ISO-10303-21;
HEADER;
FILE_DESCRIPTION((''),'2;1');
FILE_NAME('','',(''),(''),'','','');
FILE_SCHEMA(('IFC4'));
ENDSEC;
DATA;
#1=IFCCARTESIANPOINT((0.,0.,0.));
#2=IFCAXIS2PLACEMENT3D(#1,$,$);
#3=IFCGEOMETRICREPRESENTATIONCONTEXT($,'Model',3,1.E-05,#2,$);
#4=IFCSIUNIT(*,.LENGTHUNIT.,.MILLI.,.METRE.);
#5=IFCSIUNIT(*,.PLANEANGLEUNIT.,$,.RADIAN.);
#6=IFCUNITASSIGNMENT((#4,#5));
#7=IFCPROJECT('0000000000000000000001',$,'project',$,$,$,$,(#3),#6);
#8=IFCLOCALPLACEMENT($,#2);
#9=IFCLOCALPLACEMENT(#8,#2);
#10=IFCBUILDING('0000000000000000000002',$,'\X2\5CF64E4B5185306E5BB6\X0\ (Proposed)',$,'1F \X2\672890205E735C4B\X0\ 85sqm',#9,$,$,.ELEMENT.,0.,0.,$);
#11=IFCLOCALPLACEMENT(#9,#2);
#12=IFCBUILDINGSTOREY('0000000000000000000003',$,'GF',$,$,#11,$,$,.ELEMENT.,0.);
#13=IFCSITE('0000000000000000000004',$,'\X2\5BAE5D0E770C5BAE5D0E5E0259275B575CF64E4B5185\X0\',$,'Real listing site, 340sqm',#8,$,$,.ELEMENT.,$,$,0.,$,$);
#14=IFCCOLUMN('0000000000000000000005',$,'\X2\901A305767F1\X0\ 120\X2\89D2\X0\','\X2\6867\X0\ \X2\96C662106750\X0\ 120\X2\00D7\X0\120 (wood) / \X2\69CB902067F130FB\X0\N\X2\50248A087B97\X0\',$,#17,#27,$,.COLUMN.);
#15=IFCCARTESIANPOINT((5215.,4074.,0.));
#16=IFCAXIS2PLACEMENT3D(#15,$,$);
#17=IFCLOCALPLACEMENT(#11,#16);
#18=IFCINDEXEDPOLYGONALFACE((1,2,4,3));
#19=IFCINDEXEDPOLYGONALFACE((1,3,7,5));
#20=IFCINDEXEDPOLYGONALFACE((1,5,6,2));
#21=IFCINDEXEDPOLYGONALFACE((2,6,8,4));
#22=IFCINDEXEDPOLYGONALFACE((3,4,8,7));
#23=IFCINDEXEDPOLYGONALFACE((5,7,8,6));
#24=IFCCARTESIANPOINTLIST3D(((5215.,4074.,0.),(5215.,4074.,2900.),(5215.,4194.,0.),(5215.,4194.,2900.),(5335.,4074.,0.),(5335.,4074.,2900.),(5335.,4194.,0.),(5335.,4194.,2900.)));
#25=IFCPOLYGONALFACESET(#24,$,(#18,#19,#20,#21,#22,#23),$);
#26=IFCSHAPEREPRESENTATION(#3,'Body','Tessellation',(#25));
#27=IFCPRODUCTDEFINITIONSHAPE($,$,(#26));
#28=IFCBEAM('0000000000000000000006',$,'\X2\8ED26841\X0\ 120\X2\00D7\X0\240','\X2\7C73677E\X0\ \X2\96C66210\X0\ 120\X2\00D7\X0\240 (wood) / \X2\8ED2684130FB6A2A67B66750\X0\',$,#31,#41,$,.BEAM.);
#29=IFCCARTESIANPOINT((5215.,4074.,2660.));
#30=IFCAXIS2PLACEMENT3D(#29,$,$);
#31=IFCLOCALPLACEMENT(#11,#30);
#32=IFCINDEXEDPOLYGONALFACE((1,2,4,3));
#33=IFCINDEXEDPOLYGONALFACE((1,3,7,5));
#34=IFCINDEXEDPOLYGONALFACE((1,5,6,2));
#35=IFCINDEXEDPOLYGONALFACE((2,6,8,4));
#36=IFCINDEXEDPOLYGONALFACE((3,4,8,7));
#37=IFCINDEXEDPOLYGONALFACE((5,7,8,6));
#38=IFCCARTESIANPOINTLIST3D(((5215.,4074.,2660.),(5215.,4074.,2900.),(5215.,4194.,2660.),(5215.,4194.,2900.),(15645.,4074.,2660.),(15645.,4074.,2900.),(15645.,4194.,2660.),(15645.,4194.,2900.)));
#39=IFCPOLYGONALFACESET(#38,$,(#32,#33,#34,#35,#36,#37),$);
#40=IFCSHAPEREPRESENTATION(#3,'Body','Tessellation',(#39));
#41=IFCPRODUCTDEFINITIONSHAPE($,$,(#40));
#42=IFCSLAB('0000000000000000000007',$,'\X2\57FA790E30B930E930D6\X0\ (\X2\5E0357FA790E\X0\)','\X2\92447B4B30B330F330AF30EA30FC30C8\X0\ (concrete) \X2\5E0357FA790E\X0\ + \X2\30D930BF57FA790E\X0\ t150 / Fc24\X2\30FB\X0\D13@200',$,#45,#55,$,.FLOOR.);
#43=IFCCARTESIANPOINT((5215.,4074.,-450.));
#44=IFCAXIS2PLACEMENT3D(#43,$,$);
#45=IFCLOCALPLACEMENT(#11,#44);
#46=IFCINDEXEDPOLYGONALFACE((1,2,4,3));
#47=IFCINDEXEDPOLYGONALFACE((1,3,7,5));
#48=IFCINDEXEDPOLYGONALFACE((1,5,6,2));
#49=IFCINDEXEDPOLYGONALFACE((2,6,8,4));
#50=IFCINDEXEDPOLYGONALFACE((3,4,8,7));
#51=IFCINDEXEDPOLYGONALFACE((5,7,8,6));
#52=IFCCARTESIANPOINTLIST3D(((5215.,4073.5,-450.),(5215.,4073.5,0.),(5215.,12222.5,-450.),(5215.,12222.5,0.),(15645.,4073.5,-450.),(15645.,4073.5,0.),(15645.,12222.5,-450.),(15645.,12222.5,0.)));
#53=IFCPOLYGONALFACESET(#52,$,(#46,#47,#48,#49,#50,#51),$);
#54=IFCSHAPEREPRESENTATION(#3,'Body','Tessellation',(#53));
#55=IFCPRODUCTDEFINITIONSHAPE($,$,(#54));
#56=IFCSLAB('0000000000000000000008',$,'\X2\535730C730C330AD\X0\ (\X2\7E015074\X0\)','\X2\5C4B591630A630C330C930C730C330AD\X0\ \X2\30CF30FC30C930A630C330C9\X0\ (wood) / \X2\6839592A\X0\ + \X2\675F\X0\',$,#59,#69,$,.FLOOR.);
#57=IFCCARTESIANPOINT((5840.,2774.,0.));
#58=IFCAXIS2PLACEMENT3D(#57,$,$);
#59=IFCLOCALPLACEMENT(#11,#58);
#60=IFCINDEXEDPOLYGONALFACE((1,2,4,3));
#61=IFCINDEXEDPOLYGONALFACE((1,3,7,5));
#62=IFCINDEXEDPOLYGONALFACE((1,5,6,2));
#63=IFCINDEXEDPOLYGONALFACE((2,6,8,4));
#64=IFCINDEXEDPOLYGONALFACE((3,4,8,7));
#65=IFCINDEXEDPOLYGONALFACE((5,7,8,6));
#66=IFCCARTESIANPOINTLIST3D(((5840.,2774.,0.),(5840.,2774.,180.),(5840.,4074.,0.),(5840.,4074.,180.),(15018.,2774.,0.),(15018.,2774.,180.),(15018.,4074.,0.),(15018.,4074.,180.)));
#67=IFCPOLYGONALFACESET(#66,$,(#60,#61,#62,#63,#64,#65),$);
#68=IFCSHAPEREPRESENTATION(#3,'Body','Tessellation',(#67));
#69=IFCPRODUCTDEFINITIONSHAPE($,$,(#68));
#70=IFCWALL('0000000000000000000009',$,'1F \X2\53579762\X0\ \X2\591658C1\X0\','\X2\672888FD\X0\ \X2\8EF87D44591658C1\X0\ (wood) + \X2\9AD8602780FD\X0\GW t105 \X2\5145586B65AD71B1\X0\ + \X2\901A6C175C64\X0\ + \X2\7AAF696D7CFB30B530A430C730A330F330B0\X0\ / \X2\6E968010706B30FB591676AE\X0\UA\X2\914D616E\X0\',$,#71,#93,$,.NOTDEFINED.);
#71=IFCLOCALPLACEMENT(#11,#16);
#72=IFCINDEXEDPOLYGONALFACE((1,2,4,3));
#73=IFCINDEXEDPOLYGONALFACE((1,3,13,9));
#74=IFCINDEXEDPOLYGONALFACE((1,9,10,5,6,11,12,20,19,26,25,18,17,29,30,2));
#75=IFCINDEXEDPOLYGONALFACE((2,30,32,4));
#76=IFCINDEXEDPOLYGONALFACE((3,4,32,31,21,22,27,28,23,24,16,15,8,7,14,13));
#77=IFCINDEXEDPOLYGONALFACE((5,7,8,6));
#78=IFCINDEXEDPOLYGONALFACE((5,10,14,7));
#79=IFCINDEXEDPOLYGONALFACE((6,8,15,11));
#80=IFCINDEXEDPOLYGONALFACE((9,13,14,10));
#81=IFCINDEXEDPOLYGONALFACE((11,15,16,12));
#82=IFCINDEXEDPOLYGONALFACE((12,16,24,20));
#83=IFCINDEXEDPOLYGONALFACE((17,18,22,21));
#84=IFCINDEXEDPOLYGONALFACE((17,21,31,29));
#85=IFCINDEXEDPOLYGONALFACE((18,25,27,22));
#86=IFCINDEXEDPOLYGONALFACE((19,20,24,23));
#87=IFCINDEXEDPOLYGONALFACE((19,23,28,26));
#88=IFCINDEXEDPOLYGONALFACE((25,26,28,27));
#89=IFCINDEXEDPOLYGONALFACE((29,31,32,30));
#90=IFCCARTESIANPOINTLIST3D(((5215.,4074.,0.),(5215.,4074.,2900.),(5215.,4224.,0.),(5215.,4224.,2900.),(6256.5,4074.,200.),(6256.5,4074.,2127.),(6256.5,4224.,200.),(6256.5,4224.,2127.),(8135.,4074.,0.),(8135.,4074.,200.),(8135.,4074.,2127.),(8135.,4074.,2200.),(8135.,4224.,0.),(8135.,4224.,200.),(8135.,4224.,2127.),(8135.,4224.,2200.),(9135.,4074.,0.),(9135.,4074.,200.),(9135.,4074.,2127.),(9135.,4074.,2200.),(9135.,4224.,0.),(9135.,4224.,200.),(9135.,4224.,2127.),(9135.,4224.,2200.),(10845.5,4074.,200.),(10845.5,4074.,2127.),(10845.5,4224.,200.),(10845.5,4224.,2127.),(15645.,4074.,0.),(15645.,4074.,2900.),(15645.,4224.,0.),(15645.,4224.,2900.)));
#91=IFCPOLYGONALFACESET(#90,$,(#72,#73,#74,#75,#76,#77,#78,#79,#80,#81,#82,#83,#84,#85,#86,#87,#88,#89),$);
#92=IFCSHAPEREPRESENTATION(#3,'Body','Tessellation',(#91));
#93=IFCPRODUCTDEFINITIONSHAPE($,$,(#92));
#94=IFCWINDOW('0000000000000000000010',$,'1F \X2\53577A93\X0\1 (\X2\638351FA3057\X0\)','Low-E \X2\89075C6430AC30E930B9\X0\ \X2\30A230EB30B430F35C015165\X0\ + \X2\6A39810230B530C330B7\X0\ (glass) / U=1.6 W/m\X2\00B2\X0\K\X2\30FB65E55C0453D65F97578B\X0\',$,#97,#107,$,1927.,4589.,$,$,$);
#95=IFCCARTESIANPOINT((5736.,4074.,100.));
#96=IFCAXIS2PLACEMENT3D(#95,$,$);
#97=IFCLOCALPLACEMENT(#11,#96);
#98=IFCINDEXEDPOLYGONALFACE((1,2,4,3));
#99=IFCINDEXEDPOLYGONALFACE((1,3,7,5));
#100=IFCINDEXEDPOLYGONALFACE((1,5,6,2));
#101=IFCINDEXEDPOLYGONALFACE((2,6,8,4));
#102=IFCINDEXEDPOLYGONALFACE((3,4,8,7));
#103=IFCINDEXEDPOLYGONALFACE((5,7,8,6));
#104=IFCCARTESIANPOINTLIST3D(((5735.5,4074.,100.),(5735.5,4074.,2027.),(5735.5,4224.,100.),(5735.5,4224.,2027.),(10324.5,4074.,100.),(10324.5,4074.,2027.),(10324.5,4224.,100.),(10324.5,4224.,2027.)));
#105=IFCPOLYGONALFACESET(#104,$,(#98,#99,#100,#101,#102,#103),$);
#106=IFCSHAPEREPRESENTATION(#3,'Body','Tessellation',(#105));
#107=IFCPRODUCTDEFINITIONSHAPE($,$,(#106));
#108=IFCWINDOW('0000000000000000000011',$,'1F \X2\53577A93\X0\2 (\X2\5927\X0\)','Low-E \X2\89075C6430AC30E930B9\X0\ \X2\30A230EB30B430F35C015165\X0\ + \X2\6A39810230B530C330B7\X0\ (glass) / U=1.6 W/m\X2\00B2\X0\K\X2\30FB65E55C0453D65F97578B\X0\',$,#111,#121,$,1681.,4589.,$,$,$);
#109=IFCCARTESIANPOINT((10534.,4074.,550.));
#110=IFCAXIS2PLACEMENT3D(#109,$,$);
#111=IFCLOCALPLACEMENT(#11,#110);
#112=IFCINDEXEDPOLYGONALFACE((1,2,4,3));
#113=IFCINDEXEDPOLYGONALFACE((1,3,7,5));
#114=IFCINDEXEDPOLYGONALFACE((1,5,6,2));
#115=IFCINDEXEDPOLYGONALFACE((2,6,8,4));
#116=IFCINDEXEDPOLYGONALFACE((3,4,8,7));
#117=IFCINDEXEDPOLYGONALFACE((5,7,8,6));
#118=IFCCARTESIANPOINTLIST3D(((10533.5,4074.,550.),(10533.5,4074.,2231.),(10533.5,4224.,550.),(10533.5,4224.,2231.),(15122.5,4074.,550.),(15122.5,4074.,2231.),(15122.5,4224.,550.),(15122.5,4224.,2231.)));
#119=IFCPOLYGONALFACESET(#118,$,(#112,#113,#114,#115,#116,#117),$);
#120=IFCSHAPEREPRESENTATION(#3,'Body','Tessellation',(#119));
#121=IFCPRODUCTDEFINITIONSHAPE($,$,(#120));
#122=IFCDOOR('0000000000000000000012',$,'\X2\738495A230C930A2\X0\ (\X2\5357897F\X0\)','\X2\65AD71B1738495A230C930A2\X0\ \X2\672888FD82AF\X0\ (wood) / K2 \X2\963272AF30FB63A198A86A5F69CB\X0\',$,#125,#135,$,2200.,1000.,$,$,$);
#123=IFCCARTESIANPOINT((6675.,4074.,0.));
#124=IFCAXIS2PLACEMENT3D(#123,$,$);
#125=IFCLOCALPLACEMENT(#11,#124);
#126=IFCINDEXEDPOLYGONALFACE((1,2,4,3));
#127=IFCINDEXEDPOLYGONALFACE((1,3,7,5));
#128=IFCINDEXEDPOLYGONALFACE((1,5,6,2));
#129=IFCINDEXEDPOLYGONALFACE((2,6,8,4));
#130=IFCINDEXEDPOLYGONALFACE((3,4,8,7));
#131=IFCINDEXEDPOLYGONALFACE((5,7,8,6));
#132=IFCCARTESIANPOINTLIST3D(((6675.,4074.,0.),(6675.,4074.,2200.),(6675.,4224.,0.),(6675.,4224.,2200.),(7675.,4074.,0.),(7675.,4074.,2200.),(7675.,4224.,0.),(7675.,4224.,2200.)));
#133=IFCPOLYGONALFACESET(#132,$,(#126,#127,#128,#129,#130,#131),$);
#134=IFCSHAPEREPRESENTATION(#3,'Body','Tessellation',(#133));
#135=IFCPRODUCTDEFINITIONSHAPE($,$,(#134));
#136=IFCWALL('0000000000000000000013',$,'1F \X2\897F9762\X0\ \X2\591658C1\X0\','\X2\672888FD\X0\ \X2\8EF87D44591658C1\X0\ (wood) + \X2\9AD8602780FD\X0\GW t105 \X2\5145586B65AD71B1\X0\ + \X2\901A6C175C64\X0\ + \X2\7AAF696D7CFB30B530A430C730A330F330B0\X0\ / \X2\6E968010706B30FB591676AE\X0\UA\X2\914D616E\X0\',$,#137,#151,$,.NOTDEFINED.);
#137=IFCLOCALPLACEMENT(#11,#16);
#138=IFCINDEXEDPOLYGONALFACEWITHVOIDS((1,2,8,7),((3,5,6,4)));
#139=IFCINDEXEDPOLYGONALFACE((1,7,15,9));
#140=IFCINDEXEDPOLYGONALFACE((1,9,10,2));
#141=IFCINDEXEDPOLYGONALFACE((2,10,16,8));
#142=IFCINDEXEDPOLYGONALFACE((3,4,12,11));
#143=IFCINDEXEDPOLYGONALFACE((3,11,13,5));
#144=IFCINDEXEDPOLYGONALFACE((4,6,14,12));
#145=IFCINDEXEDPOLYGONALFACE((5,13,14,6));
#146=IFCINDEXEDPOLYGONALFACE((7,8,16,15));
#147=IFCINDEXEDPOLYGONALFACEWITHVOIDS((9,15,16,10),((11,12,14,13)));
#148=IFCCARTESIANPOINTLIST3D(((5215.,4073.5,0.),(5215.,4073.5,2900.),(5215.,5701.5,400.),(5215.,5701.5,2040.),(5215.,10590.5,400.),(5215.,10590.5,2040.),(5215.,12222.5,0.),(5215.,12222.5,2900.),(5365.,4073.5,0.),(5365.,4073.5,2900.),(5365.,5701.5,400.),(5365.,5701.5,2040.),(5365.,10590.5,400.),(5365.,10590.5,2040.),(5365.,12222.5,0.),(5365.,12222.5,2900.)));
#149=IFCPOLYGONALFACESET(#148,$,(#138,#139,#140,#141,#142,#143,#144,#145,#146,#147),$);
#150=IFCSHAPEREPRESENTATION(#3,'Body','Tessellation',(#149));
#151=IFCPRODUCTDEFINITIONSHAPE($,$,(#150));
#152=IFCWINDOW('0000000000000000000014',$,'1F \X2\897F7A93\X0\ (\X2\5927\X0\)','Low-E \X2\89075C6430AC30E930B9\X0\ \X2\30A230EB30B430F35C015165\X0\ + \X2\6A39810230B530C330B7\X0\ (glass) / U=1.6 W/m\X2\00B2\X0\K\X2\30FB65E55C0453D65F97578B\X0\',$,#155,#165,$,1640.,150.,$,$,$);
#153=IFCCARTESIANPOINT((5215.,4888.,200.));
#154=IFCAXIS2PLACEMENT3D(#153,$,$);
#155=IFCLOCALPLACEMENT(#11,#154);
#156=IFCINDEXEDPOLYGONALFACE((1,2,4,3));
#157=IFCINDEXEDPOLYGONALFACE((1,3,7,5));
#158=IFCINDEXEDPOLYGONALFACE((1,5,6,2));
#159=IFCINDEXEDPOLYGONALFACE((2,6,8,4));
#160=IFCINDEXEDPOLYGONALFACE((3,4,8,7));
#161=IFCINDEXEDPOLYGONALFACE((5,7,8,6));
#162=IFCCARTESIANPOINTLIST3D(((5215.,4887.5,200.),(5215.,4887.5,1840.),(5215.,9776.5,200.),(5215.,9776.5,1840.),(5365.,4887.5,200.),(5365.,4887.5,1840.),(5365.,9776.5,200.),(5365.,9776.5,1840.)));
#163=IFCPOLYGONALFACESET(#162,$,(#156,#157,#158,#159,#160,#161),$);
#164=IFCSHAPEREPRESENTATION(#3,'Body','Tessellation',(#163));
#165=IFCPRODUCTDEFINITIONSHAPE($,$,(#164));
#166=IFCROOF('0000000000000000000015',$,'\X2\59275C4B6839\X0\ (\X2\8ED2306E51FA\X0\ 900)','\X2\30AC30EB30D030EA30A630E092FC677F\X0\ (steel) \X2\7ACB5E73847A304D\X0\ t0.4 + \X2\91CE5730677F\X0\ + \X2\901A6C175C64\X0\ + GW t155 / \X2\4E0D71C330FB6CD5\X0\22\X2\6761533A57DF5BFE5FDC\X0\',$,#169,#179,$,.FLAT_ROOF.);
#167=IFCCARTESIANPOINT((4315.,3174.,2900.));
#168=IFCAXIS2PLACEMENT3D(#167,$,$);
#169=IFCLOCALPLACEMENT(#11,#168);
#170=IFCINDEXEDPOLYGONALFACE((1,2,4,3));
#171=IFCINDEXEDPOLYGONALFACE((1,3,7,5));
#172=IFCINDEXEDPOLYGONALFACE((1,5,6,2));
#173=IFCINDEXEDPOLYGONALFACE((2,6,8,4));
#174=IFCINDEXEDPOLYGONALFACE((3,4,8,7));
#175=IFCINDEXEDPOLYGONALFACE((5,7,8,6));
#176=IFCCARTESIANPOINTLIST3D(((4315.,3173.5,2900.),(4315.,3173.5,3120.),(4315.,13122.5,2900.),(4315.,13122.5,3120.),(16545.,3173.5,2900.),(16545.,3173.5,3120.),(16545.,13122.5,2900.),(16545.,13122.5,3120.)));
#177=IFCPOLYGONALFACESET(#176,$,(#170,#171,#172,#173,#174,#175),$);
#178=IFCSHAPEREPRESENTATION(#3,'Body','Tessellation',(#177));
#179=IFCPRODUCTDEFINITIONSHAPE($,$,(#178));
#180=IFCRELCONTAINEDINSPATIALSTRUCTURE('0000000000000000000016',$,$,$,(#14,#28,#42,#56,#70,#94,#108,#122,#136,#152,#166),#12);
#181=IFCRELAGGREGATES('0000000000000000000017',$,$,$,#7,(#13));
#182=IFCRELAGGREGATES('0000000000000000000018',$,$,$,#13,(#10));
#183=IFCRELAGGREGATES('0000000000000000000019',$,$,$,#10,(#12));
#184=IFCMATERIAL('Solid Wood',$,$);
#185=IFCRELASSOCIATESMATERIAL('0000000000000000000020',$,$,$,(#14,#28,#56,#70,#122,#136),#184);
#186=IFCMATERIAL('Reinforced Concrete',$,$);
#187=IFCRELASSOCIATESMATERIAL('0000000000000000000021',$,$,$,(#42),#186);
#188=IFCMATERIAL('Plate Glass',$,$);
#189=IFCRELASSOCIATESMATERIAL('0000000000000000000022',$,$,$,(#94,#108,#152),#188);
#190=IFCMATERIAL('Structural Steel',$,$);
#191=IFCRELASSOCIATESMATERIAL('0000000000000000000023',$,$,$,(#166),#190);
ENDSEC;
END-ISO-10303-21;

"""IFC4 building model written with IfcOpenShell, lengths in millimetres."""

from ifc_helpers import new_model, si_unit, frame, frame_2d, origin, place, context, project, spatial, rectangle, extrude, material, element, fill, save


model = new_model("IFC4")

# Units and contexts
model_context = context("Model", 3, precision=1e-05, world=origin())
ifc_project = project(units=[si_unit("LENGTHUNIT", "METRE", prefix="MILLI"), si_unit("PLANEANGLEUNIT", "RADIAN")], contexts=[model_context])

# Site, building, storey
site_placement = place(None, origin())
site = spatial("IfcSite", under=ifc_project, at=site_placement, Name="宮崎県宮崎市大字島之内", ObjectType="Real listing site, 340sqm", CompositionType="ELEMENT", RefElevation=0.0)
building_placement = place(site_placement, origin())
building = spatial("IfcBuilding", under=site, at=building_placement, Name="島之内の家 (Proposed)", ObjectType="1F 木造平屋 85sqm", CompositionType="ELEMENT", ElevationOfRefHeight=0.0, ElevationOfTerrain=0.0)
storey_placement = place(building_placement, origin())
storey = spatial("IfcBuildingStorey", under=building, at=storey_placement, Name="GF", CompositionType="ELEMENT", Elevation=0.0)

# Column
ifc_material_1 = material(Name="Solid Wood")
column_placement = place(storey_placement, frame((5215.0, 4074.0, 0.0)))
element("IfcColumn", 1, at=column_placement, inside=storey, material=ifc_material_1, Name="通し柱 120角", Description="桧 集成材 120×120 (wood) / 構造柱・N値計算", PredefinedType="COLUMN", context=model_context, shape_type="SweptSolid", body=[
    extrude(rectangle(XDim=120.0, YDim=120.0, at=frame_2d((60.0, 60.0))), frame((5215.0, 4074.0, 0.0)), (0.0, 0.0, 1.0), 2900.0),
])

# Beam
beam_1_placement = place(storey_placement, frame((5215.0, 4074.0, 2660.0)))
element("IfcBeam", 2, at=beam_1_placement, inside=storey, material=ifc_material_1, Name="軒桁 120×240", Description="米松 集成 120×240 (wood) / 軒桁・横架材", PredefinedType="BEAM", context=model_context, shape_type="SweptSolid", body=[
    extrude(rectangle(XDim=10430.0, YDim=120.0, at=frame_2d((5215.0, 60.0))), frame((5215.0, 4074.0, 2660.0)), (0.0, 0.0, 1.0), 240.0),
])

# Slabs
ifc_material_2 = material(Name="Reinforced Concrete")
slab_1_placement = place(storey_placement, frame((5215.0, 4074.0, -450.0)))
element("IfcSlab", 3, at=slab_1_placement, inside=storey, material=ifc_material_2, Name="基礎スラブ (布基礎)", Description="鉄筋コンクリート (concrete) 布基礎 + ベタ基礎 t150 / Fc24・D13@200", PredefinedType="FLOOR", context=model_context, shape_type="SweptSolid", body=[
    extrude(rectangle(XDim=10430.0, YDim=8149.0, at=frame_2d((5215.0, 4074.0))), frame((5215.0, 4074.0, -450.0)), (0.0, 0.0, 1.0), 450.0),
])
slab_2_placement = place(storey_placement, frame((5840.0, 2774.0, 0.0)))
element("IfcSlab", 4, at=slab_2_placement, inside=storey, material=ifc_material_1, Name="南デッキ (縁側)", Description="屋外ウッドデッキ ハードウッド (wood) / 根太 + 束", PredefinedType="FLOOR", context=model_context, shape_type="SweptSolid", body=[
    extrude(rectangle(XDim=9178.0, YDim=1300.0, at=frame_2d((4589.0, 650.0))), frame((5840.0, 2774.0, 0.0)), (0.0, 0.0, 1.0), 180.0),
])

# Wall, openings, windows, door
wall_1_placement = place(storey_placement, frame((5215.0, 4074.0, 0.0)))
wall_1 = element("IfcWall", 5, at=wall_1_placement, inside=storey, material=ifc_material_1, Name="1F 南面 外壁", Description="木製 軸組外壁 (wood) + 高性能GW t105 充填断熱 + 通気層 + 窯業系サイディング / 準耐火・外皮UA配慮", PredefinedType="NOTDEFINED", context=model_context, shape_type="SweptSolid", body=[
    extrude(rectangle(XDim=10430.0, YDim=150.0, at=frame_2d((5215.0, 75.0))), frame((5215.0, 4074.0, 0.0)), (0.0, 0.0, 1.0), 2900.0),
])
opening_1_placement = place(storey_placement, frame((5736.0, 4074.0, 100.0)))
opening_1 = element("IfcOpeningElement", 6, at=opening_1_placement, cuts=wall_1, PredefinedType="NOTDEFINED", context=model_context, shape_type="SweptSolid", body=[
    extrude(rectangle(XDim=4589.0, YDim=150.0, at=frame_2d((2294.0, 75.0))), frame((5736.0, 4074.0, 100.0)), (0.0, 0.0, 1.0), 1927.0),
])
opening_2_placement = place(storey_placement, frame((10534.0, 4074.0, 550.0)))
opening_2 = element("IfcOpeningElement", 7, at=opening_2_placement, cuts=wall_1, PredefinedType="NOTDEFINED", context=model_context, shape_type="SweptSolid", body=[
    extrude(rectangle(XDim=4589.0, YDim=150.0, at=frame_2d((2294.0, 75.0))), frame((10534.0, 4074.0, 550.0)), (0.0, 0.0, 1.0), 1681.0),
])
opening_3_placement = place(storey_placement, frame((6675.0, 4074.0, 0.0)))
opening_3 = element("IfcOpeningElement", 8, at=opening_3_placement, cuts=wall_1, PredefinedType="NOTDEFINED", context=model_context, shape_type="SweptSolid", body=[
    extrude(rectangle(XDim=1000.0, YDim=150.0, at=frame_2d((500.0, 75.0))), frame((6675.0, 4074.0, 0.0)), (0.0, 0.0, 1.0), 2200.0),
])
ifc_material_3 = material(Name="Plate Glass")
window_1_placement = place(storey_placement, frame((5736.0, 4074.0, 100.0)))
window_1 = element("IfcWindow", 9, at=window_1_placement, inside=storey, material=ifc_material_3, Name="1F 南窓1 (掃出し)", Description="Low-E 複層ガラス アルゴン封入 + 樹脂サッシ (glass) / U=1.6 W/m²K・日射取得型", OverallHeight=1927.0, OverallWidth=4589.0, context=model_context, shape_type="SweptSolid", body=[
    extrude(rectangle(XDim=4589.0, YDim=150.0, at=frame_2d((2294.0, 75.0))), frame((5736.0, 4074.0, 100.0)), (0.0, 0.0, 1.0), 1927.0),
])
fill(opening_1, window_1)
window_2_placement = place(storey_placement, frame((10534.0, 4074.0, 550.0)))
window_2 = element("IfcWindow", 10, at=window_2_placement, inside=storey, material=ifc_material_3, Name="1F 南窓2 (大)", Description="Low-E 複層ガラス アルゴン封入 + 樹脂サッシ (glass) / U=1.6 W/m²K・日射取得型", OverallHeight=1681.0, OverallWidth=4589.0, context=model_context, shape_type="SweptSolid", body=[
    extrude(rectangle(XDim=4589.0, YDim=150.0, at=frame_2d((2294.0, 75.0))), frame((10534.0, 4074.0, 550.0)), (0.0, 0.0, 1.0), 1681.0),
])
fill(opening_2, window_2)
door_placement = place(storey_placement, frame((6675.0, 4074.0, 0.0)))
door = element("IfcDoor", 11, at=door_placement, inside=storey, material=ifc_material_1, Name="玄関ドア (南西)", Description="断熱玄関ドア 木製芯 (wood) / K2 防犯・採風機構", OverallHeight=2200.0, OverallWidth=1000.0, context=model_context, shape_type="SweptSolid", body=[
    extrude(rectangle(XDim=1000.0, YDim=150.0, at=frame_2d((500.0, 75.0))), frame((6675.0, 4074.0, 0.0)), (0.0, 0.0, 1.0), 2200.0),
])
fill(opening_3, door)

# Wall, opening, window
wall_2_placement = place(storey_placement, frame((5215.0, 4074.0, 0.0)))
wall_2 = element("IfcWall", 12, at=wall_2_placement, inside=storey, material=ifc_material_1, Name="1F 西面 外壁", Description="木製 軸組外壁 (wood) + 高性能GW t105 充填断熱 + 通気層 + 窯業系サイディング / 準耐火・外皮UA配慮", PredefinedType="NOTDEFINED", context=model_context, shape_type="SweptSolid", body=[
    extrude(rectangle(XDim=150.0, YDim=8149.0, at=frame_2d((75.0, 4074.0))), frame((5215.0, 4074.0, 0.0)), (0.0, 0.0, 1.0), 2900.0),
])
opening_4_placement = place(storey_placement, frame((5215.0, 4888.0, 200.0)))
opening_4 = element("IfcOpeningElement", 13, at=opening_4_placement, cuts=wall_2, PredefinedType="NOTDEFINED", context=model_context, shape_type="SweptSolid", body=[
    extrude(rectangle(XDim=150.0, YDim=4889.0, at=frame_2d((75.0, 2444.0))), frame((5215.0, 4888.0, 200.0)), (0.0, 0.0, 1.0), 1640.0),
])
window_3_placement = place(storey_placement, frame((5215.0, 4888.0, 200.0)))
window_3 = element("IfcWindow", 14, at=window_3_placement, inside=storey, material=ifc_material_3, Name="1F 西窓 (大)", Description="Low-E 複層ガラス アルゴン封入 + 樹脂サッシ (glass) / U=1.6 W/m²K・日射取得型", OverallHeight=1640.0, OverallWidth=150.0, context=model_context, shape_type="SweptSolid", body=[
    extrude(rectangle(XDim=150.0, YDim=4889.0, at=frame_2d((75.0, 2444.0))), frame((5215.0, 4888.0, 200.0)), (0.0, 0.0, 1.0), 1640.0),
])
fill(opening_4, window_3)

# Roof
ifc_material_4 = material(Name="Structural Steel")
roof_placement = place(storey_placement, frame((4315.0, 3174.0, 2900.0)))
element("IfcRoof", 15, at=roof_placement, inside=storey, material=ifc_material_4, Name="大屋根 (軒の出 900)", Description="ガルバリウム鋼板 (steel) 立平葺き t0.4 + 野地板 + 通気層 + GW t155 / 不燃・法22条区域対応", PredefinedType="FLAT_ROOF", context=model_context, shape_type="SweptSolid", body=[
    extrude(rectangle(XDim=12230.0, YDim=9949.0, at=frame_2d((6115.0, 4974.0))), frame((4315.0, 3174.0, 2900.0)), (0.0, 0.0, 1.0), 220.0),
])

save(model, "model.ifc")
